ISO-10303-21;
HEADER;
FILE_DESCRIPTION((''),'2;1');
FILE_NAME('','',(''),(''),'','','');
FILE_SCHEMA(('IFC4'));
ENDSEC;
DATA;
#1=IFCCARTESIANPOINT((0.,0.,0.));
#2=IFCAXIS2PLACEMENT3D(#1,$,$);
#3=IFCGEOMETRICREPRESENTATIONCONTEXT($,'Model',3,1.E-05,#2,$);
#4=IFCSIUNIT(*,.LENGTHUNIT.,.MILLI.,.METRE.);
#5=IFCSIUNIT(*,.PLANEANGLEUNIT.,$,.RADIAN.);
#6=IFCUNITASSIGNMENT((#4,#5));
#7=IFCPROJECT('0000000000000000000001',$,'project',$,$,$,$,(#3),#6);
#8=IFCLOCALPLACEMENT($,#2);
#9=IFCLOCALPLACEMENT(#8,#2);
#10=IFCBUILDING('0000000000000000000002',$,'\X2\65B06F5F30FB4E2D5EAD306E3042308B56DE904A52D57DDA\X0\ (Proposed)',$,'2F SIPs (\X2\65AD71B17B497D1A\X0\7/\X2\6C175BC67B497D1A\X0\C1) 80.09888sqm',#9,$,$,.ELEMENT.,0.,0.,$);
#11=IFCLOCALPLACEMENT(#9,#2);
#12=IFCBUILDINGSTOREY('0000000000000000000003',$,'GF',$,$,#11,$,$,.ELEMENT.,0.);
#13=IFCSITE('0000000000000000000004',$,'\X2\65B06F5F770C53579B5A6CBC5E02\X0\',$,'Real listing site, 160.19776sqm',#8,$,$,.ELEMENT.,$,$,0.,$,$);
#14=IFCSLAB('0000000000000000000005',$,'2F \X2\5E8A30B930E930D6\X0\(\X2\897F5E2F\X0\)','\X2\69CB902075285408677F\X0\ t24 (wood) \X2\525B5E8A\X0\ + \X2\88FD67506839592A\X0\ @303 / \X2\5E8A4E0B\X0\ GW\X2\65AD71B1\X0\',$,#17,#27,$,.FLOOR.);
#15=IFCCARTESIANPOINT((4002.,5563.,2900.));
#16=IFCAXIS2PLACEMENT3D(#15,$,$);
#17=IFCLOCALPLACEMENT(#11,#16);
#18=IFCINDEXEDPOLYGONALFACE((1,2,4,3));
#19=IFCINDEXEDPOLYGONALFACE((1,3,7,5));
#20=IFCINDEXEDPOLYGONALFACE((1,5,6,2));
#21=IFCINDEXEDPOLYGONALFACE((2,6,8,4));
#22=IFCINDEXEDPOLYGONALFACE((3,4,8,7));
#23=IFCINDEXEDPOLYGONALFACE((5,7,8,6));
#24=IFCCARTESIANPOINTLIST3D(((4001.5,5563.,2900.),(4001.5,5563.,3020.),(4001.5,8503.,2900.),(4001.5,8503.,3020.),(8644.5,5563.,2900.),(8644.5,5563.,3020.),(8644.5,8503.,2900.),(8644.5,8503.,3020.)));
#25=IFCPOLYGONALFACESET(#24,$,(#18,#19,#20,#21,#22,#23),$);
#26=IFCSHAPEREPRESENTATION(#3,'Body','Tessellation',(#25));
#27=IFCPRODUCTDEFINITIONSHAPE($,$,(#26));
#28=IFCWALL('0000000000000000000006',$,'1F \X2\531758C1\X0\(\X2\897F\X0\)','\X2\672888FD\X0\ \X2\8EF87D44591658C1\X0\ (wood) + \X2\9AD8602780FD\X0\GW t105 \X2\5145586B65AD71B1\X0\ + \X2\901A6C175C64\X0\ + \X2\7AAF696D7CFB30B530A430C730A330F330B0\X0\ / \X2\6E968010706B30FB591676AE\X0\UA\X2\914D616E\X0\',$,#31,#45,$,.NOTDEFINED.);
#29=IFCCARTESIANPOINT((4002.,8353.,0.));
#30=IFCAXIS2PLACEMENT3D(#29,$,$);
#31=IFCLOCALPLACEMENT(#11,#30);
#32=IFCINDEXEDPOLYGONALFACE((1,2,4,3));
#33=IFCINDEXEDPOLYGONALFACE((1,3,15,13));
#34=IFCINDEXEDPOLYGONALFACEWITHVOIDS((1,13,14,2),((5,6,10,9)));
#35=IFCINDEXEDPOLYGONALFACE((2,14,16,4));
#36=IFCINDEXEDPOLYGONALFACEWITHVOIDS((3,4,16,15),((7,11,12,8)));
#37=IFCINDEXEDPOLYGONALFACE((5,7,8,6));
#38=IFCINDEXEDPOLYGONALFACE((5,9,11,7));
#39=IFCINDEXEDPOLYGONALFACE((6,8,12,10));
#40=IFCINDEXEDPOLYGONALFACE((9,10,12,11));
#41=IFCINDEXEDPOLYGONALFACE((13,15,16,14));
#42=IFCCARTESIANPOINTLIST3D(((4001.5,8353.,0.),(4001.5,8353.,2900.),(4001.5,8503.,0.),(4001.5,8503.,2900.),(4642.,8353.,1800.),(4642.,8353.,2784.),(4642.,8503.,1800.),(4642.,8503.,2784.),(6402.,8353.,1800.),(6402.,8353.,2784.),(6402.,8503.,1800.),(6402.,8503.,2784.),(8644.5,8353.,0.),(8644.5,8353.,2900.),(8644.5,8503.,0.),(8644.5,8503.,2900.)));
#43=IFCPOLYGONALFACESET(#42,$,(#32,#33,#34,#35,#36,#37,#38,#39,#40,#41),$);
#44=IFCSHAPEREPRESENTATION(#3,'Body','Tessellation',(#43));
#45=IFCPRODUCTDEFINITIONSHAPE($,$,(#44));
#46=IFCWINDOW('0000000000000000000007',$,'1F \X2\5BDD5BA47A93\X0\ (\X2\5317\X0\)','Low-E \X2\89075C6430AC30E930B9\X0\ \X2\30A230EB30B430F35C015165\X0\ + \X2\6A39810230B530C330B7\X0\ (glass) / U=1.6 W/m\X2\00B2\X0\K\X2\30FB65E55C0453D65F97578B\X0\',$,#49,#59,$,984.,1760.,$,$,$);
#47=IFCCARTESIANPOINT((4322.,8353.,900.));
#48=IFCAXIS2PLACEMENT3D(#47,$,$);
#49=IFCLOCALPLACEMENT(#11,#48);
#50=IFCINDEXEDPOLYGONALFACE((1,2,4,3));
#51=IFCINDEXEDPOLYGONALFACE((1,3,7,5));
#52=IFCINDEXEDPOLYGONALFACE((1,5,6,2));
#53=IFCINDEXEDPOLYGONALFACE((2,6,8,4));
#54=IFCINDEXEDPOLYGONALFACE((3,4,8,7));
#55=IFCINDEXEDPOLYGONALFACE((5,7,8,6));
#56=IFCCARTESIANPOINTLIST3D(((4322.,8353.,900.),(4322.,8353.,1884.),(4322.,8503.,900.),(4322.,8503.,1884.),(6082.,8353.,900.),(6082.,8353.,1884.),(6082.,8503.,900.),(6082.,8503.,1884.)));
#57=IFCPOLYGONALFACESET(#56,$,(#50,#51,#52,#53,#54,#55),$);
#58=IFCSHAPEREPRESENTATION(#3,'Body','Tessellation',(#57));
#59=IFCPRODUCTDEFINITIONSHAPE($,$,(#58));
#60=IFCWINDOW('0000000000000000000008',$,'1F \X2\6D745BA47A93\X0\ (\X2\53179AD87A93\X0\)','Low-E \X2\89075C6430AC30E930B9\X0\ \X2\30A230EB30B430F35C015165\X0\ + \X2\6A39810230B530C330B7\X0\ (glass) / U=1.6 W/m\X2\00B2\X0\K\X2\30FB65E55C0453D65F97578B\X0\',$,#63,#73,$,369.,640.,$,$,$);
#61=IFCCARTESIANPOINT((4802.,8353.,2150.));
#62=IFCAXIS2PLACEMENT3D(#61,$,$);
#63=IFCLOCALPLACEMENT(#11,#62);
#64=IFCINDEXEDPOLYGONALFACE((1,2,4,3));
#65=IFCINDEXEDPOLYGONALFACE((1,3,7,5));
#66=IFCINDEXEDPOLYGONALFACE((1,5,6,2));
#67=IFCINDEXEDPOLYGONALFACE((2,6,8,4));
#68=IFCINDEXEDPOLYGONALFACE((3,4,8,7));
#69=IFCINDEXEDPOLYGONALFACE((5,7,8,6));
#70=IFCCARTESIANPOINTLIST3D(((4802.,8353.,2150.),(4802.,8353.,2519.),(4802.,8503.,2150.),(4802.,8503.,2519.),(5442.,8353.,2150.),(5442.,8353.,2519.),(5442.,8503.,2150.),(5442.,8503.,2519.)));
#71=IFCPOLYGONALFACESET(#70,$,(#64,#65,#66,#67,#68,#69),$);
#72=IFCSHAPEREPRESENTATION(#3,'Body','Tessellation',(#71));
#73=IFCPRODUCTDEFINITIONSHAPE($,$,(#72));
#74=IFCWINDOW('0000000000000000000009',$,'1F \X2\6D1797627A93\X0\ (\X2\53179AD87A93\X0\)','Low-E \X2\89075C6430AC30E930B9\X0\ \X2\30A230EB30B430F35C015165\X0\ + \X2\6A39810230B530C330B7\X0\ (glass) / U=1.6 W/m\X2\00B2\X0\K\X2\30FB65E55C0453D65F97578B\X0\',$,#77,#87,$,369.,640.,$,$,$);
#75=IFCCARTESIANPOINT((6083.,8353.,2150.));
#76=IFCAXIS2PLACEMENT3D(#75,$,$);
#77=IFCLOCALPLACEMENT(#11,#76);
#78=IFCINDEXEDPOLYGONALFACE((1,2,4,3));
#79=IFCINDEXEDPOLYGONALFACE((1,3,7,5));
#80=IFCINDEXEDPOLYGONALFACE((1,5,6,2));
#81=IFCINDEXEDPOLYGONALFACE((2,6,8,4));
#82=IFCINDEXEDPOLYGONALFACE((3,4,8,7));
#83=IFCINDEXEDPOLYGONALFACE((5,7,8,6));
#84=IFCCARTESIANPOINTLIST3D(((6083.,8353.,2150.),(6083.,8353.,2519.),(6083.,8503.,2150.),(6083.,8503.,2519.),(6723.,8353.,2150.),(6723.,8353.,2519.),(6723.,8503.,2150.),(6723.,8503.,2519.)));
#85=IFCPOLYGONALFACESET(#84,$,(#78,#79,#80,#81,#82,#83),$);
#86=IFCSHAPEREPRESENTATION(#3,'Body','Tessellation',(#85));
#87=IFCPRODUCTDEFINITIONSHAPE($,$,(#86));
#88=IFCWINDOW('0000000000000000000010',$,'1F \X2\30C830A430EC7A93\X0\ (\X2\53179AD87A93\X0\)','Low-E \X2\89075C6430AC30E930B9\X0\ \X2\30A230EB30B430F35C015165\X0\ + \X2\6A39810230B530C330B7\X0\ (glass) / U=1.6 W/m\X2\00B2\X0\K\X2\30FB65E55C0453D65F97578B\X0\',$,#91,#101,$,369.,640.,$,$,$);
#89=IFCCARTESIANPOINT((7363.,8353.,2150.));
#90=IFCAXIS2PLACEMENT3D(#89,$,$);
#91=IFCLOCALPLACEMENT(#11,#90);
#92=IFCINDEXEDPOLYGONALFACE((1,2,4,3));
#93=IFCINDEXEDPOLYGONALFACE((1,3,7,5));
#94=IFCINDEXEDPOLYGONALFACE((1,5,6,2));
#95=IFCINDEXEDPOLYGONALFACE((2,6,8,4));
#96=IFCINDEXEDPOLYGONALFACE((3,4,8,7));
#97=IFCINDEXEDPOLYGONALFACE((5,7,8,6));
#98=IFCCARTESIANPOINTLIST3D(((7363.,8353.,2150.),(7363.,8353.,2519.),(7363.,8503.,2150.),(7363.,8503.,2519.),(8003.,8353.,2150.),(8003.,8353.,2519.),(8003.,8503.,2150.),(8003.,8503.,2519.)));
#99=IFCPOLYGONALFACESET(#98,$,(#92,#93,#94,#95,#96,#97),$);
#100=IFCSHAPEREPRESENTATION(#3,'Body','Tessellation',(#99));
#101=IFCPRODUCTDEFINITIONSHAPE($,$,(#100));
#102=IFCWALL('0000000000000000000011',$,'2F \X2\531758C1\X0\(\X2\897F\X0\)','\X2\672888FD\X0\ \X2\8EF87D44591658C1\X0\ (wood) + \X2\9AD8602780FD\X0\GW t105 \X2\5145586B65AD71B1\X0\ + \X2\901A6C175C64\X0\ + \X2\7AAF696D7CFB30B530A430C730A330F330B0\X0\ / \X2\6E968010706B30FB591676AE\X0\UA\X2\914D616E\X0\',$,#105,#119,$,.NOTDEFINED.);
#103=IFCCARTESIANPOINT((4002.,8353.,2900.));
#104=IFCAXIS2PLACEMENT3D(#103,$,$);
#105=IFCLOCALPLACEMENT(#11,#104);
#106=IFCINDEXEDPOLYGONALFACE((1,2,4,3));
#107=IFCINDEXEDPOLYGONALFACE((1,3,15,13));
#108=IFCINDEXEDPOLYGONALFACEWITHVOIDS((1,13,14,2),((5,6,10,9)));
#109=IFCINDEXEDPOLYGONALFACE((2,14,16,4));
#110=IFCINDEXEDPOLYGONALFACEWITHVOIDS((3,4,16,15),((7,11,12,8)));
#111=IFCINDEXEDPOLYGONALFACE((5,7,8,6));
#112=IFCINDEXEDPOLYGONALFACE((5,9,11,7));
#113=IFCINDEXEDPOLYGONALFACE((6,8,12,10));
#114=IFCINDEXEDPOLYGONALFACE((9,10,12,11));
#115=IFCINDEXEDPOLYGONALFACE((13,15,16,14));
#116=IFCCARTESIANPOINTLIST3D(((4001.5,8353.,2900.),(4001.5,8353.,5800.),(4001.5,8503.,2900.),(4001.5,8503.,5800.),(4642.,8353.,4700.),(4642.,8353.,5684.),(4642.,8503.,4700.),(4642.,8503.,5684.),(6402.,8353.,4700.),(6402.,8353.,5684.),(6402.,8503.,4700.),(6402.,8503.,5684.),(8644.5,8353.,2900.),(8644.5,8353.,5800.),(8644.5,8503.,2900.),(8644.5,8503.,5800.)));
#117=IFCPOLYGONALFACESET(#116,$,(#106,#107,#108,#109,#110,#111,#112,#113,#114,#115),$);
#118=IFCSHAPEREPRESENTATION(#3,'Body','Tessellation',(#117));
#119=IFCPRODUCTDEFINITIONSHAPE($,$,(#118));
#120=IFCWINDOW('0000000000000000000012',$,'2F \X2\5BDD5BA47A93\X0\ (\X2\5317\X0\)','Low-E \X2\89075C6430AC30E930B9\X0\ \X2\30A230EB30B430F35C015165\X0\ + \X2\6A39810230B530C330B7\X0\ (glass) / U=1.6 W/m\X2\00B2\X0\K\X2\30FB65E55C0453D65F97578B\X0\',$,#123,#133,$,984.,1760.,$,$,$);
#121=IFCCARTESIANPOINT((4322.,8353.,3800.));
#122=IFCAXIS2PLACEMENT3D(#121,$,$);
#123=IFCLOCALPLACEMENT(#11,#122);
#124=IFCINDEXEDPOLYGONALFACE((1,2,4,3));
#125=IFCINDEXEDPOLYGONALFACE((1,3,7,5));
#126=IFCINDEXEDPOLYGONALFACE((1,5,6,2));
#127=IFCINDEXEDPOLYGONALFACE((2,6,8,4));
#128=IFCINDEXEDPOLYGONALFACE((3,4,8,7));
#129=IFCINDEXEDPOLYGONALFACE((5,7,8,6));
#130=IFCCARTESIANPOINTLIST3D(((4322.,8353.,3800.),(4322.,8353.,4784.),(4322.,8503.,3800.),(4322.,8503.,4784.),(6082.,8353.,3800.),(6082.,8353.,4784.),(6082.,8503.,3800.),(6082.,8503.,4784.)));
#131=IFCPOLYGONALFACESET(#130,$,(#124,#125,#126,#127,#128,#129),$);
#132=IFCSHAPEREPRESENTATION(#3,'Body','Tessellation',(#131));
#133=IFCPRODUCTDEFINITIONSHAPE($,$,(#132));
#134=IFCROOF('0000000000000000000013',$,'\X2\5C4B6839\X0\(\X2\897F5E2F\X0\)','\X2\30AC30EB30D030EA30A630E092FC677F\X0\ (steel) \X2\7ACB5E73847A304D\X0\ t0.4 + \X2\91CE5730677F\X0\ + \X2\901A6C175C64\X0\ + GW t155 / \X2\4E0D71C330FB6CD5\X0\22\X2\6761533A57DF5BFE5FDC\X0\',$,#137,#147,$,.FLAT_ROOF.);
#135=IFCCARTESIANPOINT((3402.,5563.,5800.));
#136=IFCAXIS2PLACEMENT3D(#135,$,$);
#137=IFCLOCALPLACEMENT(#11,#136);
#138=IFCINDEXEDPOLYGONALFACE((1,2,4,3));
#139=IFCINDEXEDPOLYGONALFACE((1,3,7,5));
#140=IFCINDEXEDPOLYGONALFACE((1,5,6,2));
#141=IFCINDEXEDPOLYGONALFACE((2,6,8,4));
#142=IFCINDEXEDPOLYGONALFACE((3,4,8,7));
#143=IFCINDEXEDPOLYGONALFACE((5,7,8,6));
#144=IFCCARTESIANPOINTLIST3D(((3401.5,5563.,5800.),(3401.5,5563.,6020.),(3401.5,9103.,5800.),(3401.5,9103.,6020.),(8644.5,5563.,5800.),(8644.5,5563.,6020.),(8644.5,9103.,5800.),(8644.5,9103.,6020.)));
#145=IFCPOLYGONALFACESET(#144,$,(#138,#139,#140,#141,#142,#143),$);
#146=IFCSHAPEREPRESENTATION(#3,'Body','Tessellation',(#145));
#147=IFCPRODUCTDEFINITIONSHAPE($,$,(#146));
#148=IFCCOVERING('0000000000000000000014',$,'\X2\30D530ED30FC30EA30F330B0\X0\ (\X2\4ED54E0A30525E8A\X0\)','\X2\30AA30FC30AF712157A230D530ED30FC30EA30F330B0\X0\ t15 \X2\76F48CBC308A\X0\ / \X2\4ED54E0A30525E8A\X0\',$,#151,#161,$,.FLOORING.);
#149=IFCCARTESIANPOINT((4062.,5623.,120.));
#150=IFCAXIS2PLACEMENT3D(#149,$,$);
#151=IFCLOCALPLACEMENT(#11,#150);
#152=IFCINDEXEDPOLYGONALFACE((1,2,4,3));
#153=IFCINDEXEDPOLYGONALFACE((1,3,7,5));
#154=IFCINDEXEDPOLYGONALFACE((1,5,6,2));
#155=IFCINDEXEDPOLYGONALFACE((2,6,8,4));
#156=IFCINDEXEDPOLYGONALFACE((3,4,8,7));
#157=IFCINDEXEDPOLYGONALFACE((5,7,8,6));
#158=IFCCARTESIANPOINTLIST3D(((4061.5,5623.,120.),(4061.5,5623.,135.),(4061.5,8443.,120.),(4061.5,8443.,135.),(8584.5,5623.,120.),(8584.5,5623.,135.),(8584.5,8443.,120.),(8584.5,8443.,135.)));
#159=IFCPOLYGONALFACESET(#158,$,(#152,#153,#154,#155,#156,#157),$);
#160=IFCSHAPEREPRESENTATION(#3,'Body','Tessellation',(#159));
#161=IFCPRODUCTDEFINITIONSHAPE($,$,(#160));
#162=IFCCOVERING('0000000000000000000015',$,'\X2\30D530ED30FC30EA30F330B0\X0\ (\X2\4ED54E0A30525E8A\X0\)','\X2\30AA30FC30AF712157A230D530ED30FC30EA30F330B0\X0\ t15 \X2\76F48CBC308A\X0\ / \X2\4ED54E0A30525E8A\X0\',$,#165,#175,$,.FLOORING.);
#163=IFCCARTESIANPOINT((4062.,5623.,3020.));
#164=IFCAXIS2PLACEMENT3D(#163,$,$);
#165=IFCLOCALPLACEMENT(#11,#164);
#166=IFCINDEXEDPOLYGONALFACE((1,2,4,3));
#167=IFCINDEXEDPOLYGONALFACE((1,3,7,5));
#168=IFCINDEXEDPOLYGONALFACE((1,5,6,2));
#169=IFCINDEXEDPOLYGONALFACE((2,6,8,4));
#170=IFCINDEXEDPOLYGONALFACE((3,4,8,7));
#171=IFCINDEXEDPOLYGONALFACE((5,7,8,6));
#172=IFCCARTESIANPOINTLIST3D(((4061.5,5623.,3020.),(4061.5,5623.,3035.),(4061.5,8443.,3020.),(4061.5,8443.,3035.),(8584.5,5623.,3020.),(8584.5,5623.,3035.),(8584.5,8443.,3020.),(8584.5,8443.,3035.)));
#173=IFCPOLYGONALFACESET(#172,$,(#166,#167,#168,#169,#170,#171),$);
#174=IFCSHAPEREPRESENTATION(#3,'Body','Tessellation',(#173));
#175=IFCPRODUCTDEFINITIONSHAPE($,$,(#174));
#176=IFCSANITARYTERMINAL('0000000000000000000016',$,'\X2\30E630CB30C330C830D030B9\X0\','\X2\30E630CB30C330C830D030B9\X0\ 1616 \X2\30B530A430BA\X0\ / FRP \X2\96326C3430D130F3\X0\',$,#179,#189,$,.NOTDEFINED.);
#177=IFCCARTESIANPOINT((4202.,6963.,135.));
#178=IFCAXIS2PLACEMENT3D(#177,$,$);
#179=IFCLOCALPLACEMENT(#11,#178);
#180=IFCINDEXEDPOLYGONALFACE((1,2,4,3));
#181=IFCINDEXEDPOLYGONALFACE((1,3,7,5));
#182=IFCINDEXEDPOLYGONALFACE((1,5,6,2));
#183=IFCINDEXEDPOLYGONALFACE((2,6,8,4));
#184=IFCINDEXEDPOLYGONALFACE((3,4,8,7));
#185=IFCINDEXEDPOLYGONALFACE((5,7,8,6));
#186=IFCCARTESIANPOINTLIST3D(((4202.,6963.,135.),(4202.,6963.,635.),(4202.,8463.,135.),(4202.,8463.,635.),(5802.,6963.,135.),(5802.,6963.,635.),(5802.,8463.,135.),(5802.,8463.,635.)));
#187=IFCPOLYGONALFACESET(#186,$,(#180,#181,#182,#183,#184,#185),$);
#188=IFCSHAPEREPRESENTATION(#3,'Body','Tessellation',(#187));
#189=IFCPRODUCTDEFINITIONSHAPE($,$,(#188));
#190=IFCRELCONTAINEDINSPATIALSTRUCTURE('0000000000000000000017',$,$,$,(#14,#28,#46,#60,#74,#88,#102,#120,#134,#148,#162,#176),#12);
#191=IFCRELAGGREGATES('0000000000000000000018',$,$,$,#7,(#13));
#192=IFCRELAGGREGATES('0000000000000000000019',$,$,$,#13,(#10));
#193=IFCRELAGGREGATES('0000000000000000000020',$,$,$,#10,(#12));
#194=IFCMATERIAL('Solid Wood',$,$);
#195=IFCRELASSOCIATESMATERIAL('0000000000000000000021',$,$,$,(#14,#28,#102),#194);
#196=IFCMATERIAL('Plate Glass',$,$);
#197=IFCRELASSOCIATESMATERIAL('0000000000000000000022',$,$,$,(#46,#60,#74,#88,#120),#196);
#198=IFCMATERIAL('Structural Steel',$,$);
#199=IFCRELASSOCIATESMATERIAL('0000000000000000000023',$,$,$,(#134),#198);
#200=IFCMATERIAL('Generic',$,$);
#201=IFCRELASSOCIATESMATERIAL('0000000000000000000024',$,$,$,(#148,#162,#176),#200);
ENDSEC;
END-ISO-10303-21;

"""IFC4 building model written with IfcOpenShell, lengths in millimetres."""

from ifc_helpers import new_model, si_unit, frame, frame_2d, origin, place, context, project, spatial, rectangle, extrude, material, element, fill, save


model = new_model("IFC4")

# Units and contexts
model_context = context("Model", 3, precision=1e-05, world=origin())
ifc_project = project(units=[si_unit("LENGTHUNIT", "METRE", prefix="MILLI"), si_unit("PLANEANGLEUNIT", "RADIAN")], contexts=[model_context])

# Site, building, storey
site_placement = place(None, origin())
site = spatial("IfcSite", under=ifc_project, at=site_placement, Name="新潟県南魚沼市", ObjectType="Real listing site, 160.19776sqm", CompositionType="ELEMENT", RefElevation=0.0)
building_placement = place(site_placement, origin())
building = spatial("IfcBuilding", under=site, at=building_placement, Name="新潟・中庭のある回遊動線 (Proposed)", ObjectType="2F SIPs (断熱等級7/気密等級C1) 80.09888sqm", CompositionType="ELEMENT", ElevationOfRefHeight=0.0, ElevationOfTerrain=0.0)
storey_placement = place(building_placement, origin())
storey = spatial("IfcBuildingStorey", under=building, at=storey_placement, Name="GF", CompositionType="ELEMENT", Elevation=0.0)

# Slab
ifc_material_1 = material(Name="Solid Wood")
slab_1_placement = place(storey_placement, frame((4002.0, 5563.0, 2900.0)))
element("IfcSlab", 1, at=slab_1_placement, inside=storey, material=ifc_material_1, Name="2F 床スラブ(西帯)", Description="構造用合板 t24 (wood) 剛床 + 製材根太 @303 / 床下 GW断熱", PredefinedType="FLOOR", context=model_context, shape_type="SweptSolid", body=[
    extrude(rectangle(XDim=4643.0, YDim=2940.0, at=frame_2d((2321.0, 1470.0))), frame((4002.0, 5563.0, 2900.0)), (0.0, 0.0, 1.0), 120.0),
])

# Wall, openings, windows
wall_1_placement = place(storey_placement, frame((4002.0, 8353.0, 0.0)))
wall_1 = element("IfcWall", 2, at=wall_1_placement, inside=storey, material=ifc_material_1, Name="1F 北壁(西)", Description="木製 軸組外壁 (wood) + 高性能GW t105 充填断熱 + 通気層 + 窯業系サイディング / 準耐火・外皮UA配慮", PredefinedType="NOTDEFINED", context=model_context, shape_type="SweptSolid", body=[
    extrude(rectangle(XDim=4643.0, YDim=150.0, at=frame_2d((2321.0, 75.0))), frame((4002.0, 8353.0, 0.0)), (0.0, 0.0, 1.0), 2900.0),
])
opening_1_placement = place(storey_placement, frame((4322.0, 8353.0, 900.0)))
opening_1 = element("IfcOpeningElement", 3, at=opening_1_placement, cuts=wall_1, PredefinedType="NOTDEFINED", context=model_context, shape_type="SweptSolid", body=[
    extrude(rectangle(XDim=1760.0, YDim=150.0, at=frame_2d((880.0, 75.0))), frame((4322.0, 8353.0, 900.0)), (0.0, 0.0, 1.0), 984.0),
])
opening_2_placement = place(storey_placement, frame((4802.0, 8353.0, 2150.0)))
opening_2 = element("IfcOpeningElement", 4, at=opening_2_placement, cuts=wall_1, PredefinedType="NOTDEFINED", context=model_context, shape_type="SweptSolid", body=[
    extrude(rectangle(XDim=640.0, YDim=150.0, at=frame_2d((320.0, 75.0))), frame((4802.0, 8353.0, 2150.0)), (0.0, 0.0, 1.0), 369.0),
])
opening_3_placement = place(storey_placement, frame((6083.0, 8353.0, 2150.0)))
opening_3 = element("IfcOpeningElement", 5, at=opening_3_placement, cuts=wall_1, PredefinedType="NOTDEFINED", context=model_context, shape_type="SweptSolid", body=[
    extrude(rectangle(XDim=640.0, YDim=150.0, at=frame_2d((320.0, 75.0))), frame((6083.0, 8353.0, 2150.0)), (0.0, 0.0, 1.0), 369.0),
])
opening_4_placement = place(storey_placement, frame((7363.0, 8353.0, 2150.0)))
opening_4 = element("IfcOpeningElement", 6, at=opening_4_placement, cuts=wall_1, PredefinedType="NOTDEFINED", context=model_context, shape_type="SweptSolid", body=[
    extrude(rectangle(XDim=640.0, YDim=150.0, at=frame_2d((320.0, 75.0))), frame((7363.0, 8353.0, 2150.0)), (0.0, 0.0, 1.0), 369.0),
])
ifc_material_2 = material(Name="Plate Glass")
window_1_placement = place(storey_placement, frame((4322.0, 8353.0, 900.0)))
window_1 = element("IfcWindow", 7, at=window_1_placement, inside=storey, material=ifc_material_2, Name="1F 寝室窓 (北)", Description="Low-E 複層ガラス アルゴン封入 + 樹脂サッシ (glass) / U=1.6 W/m²K・日射取得型", OverallHeight=984.0, OverallWidth=1760.0, context=model_context, shape_type="SweptSolid", body=[
    extrude(rectangle(XDim=1760.0, YDim=150.0, at=frame_2d((880.0, 75.0))), frame((4322.0, 8353.0, 900.0)), (0.0, 0.0, 1.0), 984.0),
])
fill(opening_1, window_1)
window_2_placement = place(storey_placement, frame((4802.0, 8353.0, 2150.0)))
window_2 = element("IfcWindow", 8, at=window_2_placement, inside=storey, material=ifc_material_2, Name="1F 浴室窓 (北高窓)", Description="Low-E 複層ガラス アルゴン封入 + 樹脂サッシ (glass) / U=1.6 W/m²K・日射取得型", OverallHeight=369.0, OverallWidth=640.0, context=model_context, shape_type="SweptSolid", body=[
    extrude(rectangle(XDim=640.0, YDim=150.0, at=frame_2d((320.0, 75.0))), frame((4802.0, 8353.0, 2150.0)), (0.0, 0.0, 1.0), 369.0),
])
fill(opening_2, window_2)
window_3_placement = place(storey_placement, frame((6083.0, 8353.0, 2150.0)))
window_3 = element("IfcWindow", 9, at=window_3_placement, inside=storey, material=ifc_material_2, Name="1F 洗面窓 (北高窓)", Description="Low-E 複層ガラス アルゴン封入 + 樹脂サッシ (glass) / U=1.6 W/m²K・日射取得型", OverallHeight=369.0, OverallWidth=640.0, context=model_context, shape_type="SweptSolid", body=[
    extrude(rectangle(XDim=640.0, YDim=150.0, at=frame_2d((320.0, 75.0))), frame((6083.0, 8353.0, 2150.0)), (0.0, 0.0, 1.0), 369.0),
])
fill(opening_3, window_3)
window_4_placement = place(storey_placement, frame((7363.0, 8353.0, 2150.0)))
window_4 = element("IfcWindow", 10, at=window_4_placement, inside=storey, material=ifc_material_2, Name="1F トイレ窓 (北高窓)", Description="Low-E 複層ガラス アルゴン封入 + 樹脂サッシ (glass) / U=1.6 W/m²K・日射取得型", OverallHeight=369.0, OverallWidth=640.0, context=model_context, shape_type="SweptSolid", body=[
    extrude(rectangle(XDim=640.0, YDim=150.0, at=frame_2d((320.0, 75.0))), frame((7363.0, 8353.0, 2150.0)), (0.0, 0.0, 1.0), 369.0),
])
fill(opening_4, window_4)

# Wall, opening, window
wall_2_placement = place(storey_placement, frame((4002.0, 8353.0, 2900.0)))
wall_2 = element("IfcWall", 11, at=wall_2_placement, inside=storey, material=ifc_material_1, Name="2F 北壁(西)", Description="木製 軸組外壁 (wood) + 高性能GW t105 充填断熱 + 通気層 + 窯業系サイディング / 準耐火・外皮UA配慮", PredefinedType="NOTDEFINED", context=model_context, shape_type="SweptSolid", body=[
    extrude(rectangle(XDim=4643.0, YDim=150.0, at=frame_2d((2321.0, 75.0))), frame((4002.0, 8353.0, 2900.0)), (0.0, 0.0, 1.0), 2900.0),
])
opening_5_placement = place(storey_placement, frame((4322.0, 8353.0, 3800.0)))
opening_5 = element("IfcOpeningElement", 12, at=opening_5_placement, cuts=wall_2, PredefinedType="NOTDEFINED", context=model_context, shape_type="SweptSolid", body=[
    extrude(rectangle(XDim=1760.0, YDim=150.0, at=frame_2d((880.0, 75.0))), frame((4322.0, 8353.0, 3800.0)), (0.0, 0.0, 1.0), 984.0),
])
window_5_placement = place(storey_placement, frame((4322.0, 8353.0, 3800.0)))
window_5 = element("IfcWindow", 13, at=window_5_placement, inside=storey, material=ifc_material_2, Name="2F 寝室窓 (北)", Description="Low-E 複層ガラス アルゴン封入 + 樹脂サッシ (glass) / U=1.6 W/m²K・日射取得型", OverallHeight=984.0, OverallWidth=1760.0, context=model_context, shape_type="SweptSolid", body=[
    extrude(rectangle(XDim=1760.0, YDim=150.0, at=frame_2d((880.0, 75.0))), frame((4322.0, 8353.0, 3800.0)), (0.0, 0.0, 1.0), 984.0),
])
fill(opening_5, window_5)

# Roof
ifc_material_3 = material(Name="Structural Steel")
for number, where, name in (
    (14, (3402.0, 5563.0, 5800.0), "屋根(西帯)"),
):
    element("IfcRoof", number, at=place(storey_placement, frame(where)), inside=storey, material=ifc_material_3, Name=name, Description="ガルバリウム鋼板 (steel) 立平葺き t0.4 + 野地板 + 通気層 + GW t155 / 不燃・法22条区域対応", PredefinedType="FLAT_ROOF", context=model_context, shape_type="SweptSolid", body=[
        extrude(rectangle(XDim=5243.0, YDim=3540.0, at=frame_2d((2621.0, 1770.0))), frame((3402.0, 5563.0, 5800.0)), (0.0, 0.0, 1.0), 220.0),
    ])

# Coverings
ifc_material_4 = material(Name="Generic")
covering_1_placement = place(storey_placement, frame((4062.0, 5623.0, 120.0)))
element("IfcCovering", 15, at=covering_1_placement, inside=storey, material=ifc_material_4, Name="フローリング (仕上げ床)", Description="オーク無垢フローリング t15 直貼り / 仕上げ床", PredefinedType="FLOORING", context=model_context, shape_type="SweptSolid", body=[
    extrude(rectangle(XDim=4523.0, YDim=2820.0, at=frame_2d((2261.0, 1410.0))), frame((4062.0, 5623.0, 120.0)), (0.0, 0.0, 1.0), 15.0),
])
covering_2_placement = place(storey_placement, frame((4062.0, 5623.0, 3020.0)))
element("IfcCovering", 16, at=covering_2_placement, inside=storey, material=ifc_material_4, Name="フローリング (仕上げ床)", Description="オーク無垢フローリング t15 直貼り / 仕上げ床", PredefinedType="FLOORING", context=model_context, shape_type="SweptSolid", body=[
    extrude(rectangle(XDim=4523.0, YDim=2820.0, at=frame_2d((2261.0, 1410.0))), frame((4062.0, 5623.0, 3020.0)), (0.0, 0.0, 1.0), 15.0),
])

# Sanitary terminal
sanitary_terminal_placement = place(storey_placement, frame((4202.0, 6963.0, 135.0)))
element("IfcSanitaryTerminal", 17, at=sanitary_terminal_placement, inside=storey, material=ifc_material_4, Name="ユニットバス", Description="ユニットバス 1616 サイズ / FRP 防水パン", PredefinedType="NOTDEFINED", context=model_context, shape_type="SweptSolid", body=[
    extrude(rectangle(XDim=1600.0, YDim=1500.0, at=frame_2d((800.0, 750.0))), frame((4202.0, 6963.0, 135.0)), (0.0, 0.0, 1.0), 500.0),
])

save(model, "model.ifc")
